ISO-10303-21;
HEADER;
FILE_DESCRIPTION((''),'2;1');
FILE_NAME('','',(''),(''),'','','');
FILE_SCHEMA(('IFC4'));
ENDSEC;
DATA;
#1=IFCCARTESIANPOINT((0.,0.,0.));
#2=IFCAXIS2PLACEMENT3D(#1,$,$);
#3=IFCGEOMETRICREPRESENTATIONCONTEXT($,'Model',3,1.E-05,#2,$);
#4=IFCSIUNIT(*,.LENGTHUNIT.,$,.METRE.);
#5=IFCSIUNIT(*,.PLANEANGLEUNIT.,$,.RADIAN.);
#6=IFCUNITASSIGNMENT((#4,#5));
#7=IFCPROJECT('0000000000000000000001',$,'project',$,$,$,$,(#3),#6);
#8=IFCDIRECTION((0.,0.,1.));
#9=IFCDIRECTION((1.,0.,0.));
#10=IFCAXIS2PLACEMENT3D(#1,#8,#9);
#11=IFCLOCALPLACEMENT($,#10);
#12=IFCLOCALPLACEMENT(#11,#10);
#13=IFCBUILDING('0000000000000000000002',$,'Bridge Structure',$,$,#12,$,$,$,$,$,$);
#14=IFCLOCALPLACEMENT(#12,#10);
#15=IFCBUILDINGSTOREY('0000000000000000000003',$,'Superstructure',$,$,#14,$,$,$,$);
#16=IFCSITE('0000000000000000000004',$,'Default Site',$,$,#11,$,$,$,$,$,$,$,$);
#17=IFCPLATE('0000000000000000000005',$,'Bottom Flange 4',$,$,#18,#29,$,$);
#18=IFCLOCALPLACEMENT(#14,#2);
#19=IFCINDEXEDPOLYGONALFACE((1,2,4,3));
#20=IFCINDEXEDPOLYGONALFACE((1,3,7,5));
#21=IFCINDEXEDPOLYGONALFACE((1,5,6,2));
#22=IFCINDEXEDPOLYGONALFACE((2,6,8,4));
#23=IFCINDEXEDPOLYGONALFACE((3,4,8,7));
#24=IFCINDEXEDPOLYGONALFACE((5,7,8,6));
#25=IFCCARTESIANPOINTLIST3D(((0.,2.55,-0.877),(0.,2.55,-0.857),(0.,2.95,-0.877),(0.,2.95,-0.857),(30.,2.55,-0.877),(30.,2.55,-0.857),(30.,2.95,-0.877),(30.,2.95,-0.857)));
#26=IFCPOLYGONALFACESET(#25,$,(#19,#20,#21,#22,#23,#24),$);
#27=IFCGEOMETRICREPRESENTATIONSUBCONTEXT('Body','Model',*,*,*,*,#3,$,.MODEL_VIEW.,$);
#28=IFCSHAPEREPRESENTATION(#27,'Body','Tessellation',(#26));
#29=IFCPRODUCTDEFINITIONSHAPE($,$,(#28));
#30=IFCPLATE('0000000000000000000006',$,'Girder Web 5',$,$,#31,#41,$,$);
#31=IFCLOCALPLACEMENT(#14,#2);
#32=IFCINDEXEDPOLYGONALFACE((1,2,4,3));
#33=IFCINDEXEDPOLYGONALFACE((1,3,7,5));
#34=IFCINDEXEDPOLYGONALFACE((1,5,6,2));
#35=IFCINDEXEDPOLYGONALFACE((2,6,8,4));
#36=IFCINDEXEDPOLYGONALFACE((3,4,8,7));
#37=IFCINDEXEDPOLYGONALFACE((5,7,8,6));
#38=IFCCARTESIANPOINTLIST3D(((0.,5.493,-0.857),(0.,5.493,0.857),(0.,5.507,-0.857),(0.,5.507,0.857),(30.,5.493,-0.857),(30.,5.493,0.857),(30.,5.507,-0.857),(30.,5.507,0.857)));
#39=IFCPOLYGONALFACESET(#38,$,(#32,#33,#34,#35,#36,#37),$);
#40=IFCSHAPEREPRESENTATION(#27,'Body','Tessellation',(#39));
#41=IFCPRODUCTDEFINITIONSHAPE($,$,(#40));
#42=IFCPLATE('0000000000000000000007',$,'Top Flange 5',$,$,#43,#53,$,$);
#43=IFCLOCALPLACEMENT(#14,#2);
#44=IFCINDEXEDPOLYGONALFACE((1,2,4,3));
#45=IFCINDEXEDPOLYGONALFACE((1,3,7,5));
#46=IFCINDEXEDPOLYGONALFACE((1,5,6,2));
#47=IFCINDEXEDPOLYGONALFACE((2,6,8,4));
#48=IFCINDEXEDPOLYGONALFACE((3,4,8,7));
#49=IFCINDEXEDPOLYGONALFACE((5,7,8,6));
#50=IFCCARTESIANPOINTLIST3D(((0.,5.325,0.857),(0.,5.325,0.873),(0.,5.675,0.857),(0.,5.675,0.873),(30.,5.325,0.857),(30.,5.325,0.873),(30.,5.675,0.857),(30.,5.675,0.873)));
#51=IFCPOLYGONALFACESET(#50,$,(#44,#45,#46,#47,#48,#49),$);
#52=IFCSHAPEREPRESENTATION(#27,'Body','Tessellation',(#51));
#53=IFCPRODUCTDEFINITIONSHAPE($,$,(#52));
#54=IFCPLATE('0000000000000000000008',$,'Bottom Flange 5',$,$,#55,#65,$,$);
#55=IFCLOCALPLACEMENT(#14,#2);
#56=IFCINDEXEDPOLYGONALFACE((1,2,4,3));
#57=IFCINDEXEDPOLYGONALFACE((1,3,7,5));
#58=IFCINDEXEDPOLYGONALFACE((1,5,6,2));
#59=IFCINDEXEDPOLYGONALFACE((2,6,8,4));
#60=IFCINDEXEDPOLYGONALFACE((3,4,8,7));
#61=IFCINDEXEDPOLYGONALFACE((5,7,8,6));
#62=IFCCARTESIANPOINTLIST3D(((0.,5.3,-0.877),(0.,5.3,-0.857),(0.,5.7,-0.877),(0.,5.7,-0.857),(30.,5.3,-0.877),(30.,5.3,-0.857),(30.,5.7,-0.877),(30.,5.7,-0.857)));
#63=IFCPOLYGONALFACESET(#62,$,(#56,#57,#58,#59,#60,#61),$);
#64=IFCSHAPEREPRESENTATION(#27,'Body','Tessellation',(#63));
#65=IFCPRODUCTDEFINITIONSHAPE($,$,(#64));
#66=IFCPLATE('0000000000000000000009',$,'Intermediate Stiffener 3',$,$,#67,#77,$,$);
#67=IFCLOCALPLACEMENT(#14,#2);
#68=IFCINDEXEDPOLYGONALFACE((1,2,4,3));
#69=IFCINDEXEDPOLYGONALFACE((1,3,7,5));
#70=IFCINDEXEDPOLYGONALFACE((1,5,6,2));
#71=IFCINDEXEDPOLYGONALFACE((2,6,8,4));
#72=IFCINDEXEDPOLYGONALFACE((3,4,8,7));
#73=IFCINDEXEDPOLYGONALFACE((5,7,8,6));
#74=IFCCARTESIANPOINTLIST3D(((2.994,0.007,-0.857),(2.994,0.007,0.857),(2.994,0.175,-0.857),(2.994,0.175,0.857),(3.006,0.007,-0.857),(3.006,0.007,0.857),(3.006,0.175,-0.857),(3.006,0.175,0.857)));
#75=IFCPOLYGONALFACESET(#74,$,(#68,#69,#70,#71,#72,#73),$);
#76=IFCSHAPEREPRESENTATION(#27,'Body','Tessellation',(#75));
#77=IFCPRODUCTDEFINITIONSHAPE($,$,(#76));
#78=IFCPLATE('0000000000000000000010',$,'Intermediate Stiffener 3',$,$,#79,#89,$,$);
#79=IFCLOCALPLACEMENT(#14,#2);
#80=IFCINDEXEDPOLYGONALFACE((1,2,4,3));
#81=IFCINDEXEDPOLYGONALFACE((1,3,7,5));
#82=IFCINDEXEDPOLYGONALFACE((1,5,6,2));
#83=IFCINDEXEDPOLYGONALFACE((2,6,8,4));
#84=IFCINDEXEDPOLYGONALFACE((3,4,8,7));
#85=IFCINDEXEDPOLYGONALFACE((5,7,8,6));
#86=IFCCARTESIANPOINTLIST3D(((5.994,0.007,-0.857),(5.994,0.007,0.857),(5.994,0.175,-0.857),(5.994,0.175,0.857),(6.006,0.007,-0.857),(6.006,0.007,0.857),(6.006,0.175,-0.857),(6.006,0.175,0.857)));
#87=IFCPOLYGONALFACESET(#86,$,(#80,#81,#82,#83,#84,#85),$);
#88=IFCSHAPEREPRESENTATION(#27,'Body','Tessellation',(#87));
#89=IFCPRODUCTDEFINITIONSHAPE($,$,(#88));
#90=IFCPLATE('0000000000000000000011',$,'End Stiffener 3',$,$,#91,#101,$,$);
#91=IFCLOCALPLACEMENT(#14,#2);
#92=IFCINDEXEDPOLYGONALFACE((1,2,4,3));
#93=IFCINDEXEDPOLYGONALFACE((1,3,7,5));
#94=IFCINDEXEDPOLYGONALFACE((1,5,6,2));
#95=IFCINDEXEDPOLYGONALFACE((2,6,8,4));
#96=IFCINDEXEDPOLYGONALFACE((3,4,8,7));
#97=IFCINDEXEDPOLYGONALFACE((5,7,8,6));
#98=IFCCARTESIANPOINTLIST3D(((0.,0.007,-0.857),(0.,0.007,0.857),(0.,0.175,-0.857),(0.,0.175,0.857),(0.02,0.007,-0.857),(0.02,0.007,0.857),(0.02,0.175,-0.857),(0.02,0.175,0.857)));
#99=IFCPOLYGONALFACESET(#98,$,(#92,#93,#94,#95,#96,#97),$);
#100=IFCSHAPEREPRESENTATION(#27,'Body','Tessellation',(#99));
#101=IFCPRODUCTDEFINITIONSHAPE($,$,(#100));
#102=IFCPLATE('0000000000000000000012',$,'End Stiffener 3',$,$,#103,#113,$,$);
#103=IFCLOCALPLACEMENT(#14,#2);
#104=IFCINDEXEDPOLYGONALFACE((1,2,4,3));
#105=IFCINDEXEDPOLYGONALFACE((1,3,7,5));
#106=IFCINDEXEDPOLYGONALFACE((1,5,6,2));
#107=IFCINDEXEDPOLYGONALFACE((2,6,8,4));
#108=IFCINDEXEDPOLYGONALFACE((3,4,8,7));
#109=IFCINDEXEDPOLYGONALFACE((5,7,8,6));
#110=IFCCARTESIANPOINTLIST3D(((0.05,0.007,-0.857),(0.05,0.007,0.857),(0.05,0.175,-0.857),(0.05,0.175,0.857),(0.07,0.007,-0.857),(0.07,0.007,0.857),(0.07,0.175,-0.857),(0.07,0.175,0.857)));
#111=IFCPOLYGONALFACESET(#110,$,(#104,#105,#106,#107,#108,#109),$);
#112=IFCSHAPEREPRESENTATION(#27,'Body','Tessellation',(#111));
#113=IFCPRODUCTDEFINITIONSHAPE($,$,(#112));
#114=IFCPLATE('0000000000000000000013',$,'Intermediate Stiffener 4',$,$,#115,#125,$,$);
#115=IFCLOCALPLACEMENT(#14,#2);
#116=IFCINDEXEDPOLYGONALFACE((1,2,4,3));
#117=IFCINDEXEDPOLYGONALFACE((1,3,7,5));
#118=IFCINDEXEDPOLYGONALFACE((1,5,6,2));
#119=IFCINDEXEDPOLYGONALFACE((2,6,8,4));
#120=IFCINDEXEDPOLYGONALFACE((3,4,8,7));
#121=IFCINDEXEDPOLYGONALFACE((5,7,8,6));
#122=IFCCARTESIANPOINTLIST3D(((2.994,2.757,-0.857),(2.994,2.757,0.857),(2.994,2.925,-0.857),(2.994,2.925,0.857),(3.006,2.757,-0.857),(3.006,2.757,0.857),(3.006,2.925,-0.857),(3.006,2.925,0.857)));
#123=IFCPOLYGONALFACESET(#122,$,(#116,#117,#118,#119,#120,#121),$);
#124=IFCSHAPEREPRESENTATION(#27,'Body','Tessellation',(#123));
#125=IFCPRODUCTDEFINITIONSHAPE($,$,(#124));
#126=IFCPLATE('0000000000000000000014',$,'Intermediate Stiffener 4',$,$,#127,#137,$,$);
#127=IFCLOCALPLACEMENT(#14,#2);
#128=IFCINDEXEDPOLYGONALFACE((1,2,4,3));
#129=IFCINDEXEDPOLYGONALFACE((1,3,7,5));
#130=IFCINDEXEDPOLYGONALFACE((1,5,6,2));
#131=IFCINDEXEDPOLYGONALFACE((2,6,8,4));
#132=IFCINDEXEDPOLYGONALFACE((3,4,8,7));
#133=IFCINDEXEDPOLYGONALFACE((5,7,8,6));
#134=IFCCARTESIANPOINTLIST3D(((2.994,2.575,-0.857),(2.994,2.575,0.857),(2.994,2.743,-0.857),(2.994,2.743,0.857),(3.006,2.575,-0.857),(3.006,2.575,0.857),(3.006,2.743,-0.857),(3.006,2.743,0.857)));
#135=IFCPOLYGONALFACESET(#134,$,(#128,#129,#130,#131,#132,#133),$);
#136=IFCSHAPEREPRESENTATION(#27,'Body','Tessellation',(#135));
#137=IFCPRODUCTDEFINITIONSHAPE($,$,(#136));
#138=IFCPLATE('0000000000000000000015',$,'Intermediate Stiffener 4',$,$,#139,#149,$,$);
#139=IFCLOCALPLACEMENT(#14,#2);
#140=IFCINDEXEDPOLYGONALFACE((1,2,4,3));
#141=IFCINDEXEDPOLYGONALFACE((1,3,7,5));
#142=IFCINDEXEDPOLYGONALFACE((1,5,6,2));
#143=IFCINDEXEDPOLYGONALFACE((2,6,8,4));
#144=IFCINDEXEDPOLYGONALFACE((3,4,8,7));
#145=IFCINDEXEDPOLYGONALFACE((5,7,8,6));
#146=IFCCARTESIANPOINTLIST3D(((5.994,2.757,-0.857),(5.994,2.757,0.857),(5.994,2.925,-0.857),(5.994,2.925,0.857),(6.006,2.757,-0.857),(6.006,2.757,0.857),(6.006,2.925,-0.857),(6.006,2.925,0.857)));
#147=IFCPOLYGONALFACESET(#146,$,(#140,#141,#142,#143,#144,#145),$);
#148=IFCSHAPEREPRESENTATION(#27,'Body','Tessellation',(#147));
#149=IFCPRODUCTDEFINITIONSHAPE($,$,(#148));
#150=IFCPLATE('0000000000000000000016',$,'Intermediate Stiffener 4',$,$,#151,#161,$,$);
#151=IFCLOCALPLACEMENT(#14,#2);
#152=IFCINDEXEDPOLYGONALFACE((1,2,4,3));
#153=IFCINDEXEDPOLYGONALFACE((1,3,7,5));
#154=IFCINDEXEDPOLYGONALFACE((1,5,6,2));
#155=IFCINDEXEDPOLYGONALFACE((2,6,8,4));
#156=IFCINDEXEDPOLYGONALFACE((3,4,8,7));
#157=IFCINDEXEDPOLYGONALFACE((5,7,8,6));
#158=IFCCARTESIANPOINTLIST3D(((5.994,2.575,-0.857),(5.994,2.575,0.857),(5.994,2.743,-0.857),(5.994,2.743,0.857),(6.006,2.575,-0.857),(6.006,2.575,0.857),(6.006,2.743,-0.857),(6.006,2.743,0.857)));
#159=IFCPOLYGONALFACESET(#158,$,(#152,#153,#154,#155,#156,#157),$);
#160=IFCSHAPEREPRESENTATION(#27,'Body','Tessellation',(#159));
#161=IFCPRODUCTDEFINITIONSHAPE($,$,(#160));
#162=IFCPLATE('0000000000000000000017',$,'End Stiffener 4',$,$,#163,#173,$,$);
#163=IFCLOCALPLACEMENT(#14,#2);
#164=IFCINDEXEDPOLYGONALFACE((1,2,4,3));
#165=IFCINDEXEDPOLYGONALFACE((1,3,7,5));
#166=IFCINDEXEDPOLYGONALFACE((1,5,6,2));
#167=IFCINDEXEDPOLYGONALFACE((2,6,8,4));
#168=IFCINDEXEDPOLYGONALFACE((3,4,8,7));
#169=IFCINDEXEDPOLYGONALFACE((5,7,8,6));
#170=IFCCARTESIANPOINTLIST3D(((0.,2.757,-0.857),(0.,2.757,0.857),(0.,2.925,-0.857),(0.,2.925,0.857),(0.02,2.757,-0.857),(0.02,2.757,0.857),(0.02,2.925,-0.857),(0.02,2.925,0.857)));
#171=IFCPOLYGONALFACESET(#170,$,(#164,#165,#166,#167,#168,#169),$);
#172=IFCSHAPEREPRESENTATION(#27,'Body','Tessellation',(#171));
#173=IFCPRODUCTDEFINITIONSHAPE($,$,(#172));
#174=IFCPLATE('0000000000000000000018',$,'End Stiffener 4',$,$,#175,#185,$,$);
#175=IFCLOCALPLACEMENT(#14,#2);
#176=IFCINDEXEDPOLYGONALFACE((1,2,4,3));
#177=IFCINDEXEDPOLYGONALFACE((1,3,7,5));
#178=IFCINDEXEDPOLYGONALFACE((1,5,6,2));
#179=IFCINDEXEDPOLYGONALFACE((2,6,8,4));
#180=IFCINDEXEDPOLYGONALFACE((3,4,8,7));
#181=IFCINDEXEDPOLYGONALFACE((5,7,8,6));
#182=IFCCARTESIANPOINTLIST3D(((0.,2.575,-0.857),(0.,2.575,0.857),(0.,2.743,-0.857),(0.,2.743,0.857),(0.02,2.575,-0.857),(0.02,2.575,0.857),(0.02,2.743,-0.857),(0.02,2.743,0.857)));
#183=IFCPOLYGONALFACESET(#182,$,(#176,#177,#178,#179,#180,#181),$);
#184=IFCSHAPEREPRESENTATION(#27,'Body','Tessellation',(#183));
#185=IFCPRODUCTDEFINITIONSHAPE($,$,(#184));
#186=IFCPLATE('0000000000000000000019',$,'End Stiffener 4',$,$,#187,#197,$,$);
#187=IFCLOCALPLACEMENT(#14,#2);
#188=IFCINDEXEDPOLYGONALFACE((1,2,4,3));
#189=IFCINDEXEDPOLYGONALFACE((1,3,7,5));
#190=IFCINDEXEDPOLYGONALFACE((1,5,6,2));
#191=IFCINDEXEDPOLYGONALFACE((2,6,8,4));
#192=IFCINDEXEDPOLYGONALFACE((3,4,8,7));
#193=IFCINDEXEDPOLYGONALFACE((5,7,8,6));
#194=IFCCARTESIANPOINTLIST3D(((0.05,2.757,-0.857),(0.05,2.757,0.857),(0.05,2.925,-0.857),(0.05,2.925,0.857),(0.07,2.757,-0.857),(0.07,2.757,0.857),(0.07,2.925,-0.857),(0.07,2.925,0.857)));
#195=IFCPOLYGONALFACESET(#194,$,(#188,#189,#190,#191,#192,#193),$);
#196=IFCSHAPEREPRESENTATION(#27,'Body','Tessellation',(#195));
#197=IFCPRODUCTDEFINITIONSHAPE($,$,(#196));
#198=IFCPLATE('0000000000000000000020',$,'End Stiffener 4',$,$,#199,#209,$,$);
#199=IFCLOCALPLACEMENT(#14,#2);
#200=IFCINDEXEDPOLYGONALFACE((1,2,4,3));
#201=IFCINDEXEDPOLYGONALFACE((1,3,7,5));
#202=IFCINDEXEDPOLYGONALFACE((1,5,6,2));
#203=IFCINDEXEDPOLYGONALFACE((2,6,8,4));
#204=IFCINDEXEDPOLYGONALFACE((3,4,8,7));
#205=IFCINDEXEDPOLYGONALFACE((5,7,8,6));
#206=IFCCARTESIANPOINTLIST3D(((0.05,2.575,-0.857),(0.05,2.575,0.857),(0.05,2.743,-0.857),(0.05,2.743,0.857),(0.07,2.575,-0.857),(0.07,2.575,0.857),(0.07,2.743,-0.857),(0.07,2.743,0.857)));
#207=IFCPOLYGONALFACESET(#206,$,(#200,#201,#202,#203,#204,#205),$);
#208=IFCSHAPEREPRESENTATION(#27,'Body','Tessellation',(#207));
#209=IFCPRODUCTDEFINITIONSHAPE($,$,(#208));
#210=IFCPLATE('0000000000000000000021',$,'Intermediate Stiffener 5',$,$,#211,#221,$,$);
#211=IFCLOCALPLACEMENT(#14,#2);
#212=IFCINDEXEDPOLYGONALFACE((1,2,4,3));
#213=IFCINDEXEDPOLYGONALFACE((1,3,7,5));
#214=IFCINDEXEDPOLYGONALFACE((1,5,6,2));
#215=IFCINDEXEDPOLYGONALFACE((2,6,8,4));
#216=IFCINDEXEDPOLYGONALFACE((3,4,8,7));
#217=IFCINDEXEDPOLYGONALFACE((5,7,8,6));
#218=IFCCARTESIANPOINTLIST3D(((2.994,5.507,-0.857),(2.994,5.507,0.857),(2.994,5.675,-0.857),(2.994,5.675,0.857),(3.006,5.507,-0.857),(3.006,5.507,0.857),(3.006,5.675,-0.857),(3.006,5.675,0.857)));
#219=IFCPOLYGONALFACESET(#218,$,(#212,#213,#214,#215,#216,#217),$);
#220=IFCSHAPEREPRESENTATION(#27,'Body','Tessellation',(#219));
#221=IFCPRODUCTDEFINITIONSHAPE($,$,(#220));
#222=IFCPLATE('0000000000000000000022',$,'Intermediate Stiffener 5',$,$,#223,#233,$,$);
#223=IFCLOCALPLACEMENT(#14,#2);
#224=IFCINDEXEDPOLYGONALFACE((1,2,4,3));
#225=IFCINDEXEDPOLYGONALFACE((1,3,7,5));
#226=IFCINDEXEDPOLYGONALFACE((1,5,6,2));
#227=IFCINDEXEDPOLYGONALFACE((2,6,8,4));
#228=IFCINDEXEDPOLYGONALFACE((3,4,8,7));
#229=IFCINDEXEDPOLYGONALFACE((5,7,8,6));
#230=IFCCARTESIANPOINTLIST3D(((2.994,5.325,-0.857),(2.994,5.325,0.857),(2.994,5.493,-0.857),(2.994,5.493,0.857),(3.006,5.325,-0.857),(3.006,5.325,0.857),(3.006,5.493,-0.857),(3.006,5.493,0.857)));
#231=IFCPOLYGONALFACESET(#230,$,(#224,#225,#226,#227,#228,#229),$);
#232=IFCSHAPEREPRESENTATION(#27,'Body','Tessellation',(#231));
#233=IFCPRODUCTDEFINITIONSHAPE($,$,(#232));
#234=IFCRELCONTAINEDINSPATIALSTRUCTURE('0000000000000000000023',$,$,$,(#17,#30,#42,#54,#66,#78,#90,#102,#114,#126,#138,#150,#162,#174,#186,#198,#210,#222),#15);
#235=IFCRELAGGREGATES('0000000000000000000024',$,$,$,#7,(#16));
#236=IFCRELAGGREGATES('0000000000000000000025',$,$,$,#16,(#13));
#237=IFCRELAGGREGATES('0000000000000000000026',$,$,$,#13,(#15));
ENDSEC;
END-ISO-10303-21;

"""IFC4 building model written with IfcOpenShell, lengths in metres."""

from ifc_helpers import new_model, si_unit, frame, origin, origin_with_axes, origin_2d_with_axis, place, context, subcontext, project, spatial, rectangle, extrude, element, save


model = new_model("IFC4")

# Units and contexts
model_context = context("Model", 3, precision=1e-05, world=origin())
body_context = subcontext(model_context, "Body", "Model", "MODEL_VIEW")
ifc_project = project(units=[si_unit("LENGTHUNIT", "METRE"), si_unit("PLANEANGLEUNIT", "RADIAN")], contexts=[model_context])

# Site, building, storey
site_placement = place(None, origin_with_axes())
site = spatial("IfcSite", under=ifc_project, at=site_placement, Name="Default Site")
building_placement = place(site_placement, origin_with_axes())
building = spatial("IfcBuilding", under=site, at=building_placement, Name="Bridge Structure")
storey_placement = place(building_placement, origin_with_axes())
storey = spatial("IfcBuildingStorey", under=building, at=storey_placement, Name="Superstructure")

# Plates
plate_1_placement = place(storey_placement, frame((0.0, 2.75, -0.867), z_axis=(1.0, 0.0, 0.0), x_axis=(0.0, 1.0, 0.0)))
element("IfcPlate", 1, at=plate_1_placement, inside=storey, Name="Bottom Flange 4", context=body_context, shape_type="SweptSolid", body=[
    extrude(rectangle(XDim=0.4, YDim=0.02, at=origin_2d_with_axis()), origin_with_axes(), (0.0, 0.0, 1.0), 30.0),
])
plate_2_placement = place(storey_placement, frame((0.0, 5.5, 0.0), z_axis=(1.0, 0.0, 0.0), x_axis=(0.0, 1.0, 0.0)))
element("IfcPlate", 2, at=plate_2_placement, inside=storey, Name="Girder Web 5", context=body_context, shape_type="SweptSolid", body=[
    extrude(rectangle(XDim=0.014, YDim=1.714, at=origin_2d_with_axis()), origin_with_axes(), (0.0, 0.0, 1.0), 30.0),
])
plate_3_placement = place(storey_placement, frame((0.0, 5.5, 0.865), z_axis=(1.0, 0.0, 0.0), x_axis=(0.0, 1.0, 0.0)))
element("IfcPlate", 3, at=plate_3_placement, inside=storey, Name="Top Flange 5", context=body_context, shape_type="SweptSolid", body=[
    extrude(rectangle(XDim=0.35, YDim=0.016, at=origin_2d_with_axis()), origin_with_axes(), (0.0, 0.0, 1.0), 30.0),
])
plate_4_placement = place(storey_placement, frame((0.0, 5.5, -0.867), z_axis=(1.0, 0.0, 0.0), x_axis=(0.0, 1.0, 0.0)))
element("IfcPlate", 4, at=plate_4_placement, inside=storey, Name="Bottom Flange 5", context=body_context, shape_type="SweptSolid", body=[
    extrude(rectangle(XDim=0.4, YDim=0.02, at=origin_2d_with_axis()), origin_with_axes(), (0.0, 0.0, 1.0), 30.0),
])
for number, where, z_axis, x_axis, name in (
    (5, (3.0, 0.091, -0.857), (0.0, 0.0, 1.0), (1.0, 0.0, 0.0), "Intermediate Stiffener 3"),
    (6, (6.0, 0.091, -0.857), (0.0, 0.0, 1.0), (1.0, 0.0, 0.0), "Intermediate Stiffener 3"),
):
    element("IfcPlate", number, at=place(storey_placement, frame(where, z_axis=z_axis, x_axis=x_axis)), inside=storey, Name=name, context=body_context, shape_type="SweptSolid", body=[
        extrude(rectangle(XDim=0.012, YDim=0.168, at=origin_2d_with_axis()), origin_with_axes(), (0.0, 0.0, 1.0), 1.714),
    ])
for number, where, z_axis, x_axis, name in (
    (7, (0.01, 0.091, -0.857), (0.0, 0.0, 1.0), (1.0, 0.0, 0.0), "End Stiffener 3"),
    (8, (0.06, 0.091, -0.857), (0.0, 0.0, 1.0), (1.0, 0.0, 0.0), "End Stiffener 3"),
):
    element("IfcPlate", number, at=place(storey_placement, frame(where, z_axis=z_axis, x_axis=x_axis)), inside=storey, Name=name, context=body_context, shape_type="SweptSolid", body=[
        extrude(rectangle(XDim=0.02, YDim=0.168, at=origin_2d_with_axis()), origin_with_axes(), (0.0, 0.0, 1.0), 1.714),
    ])
for number, where, z_axis, x_axis, name in (
    (9, (3.0, 2.841, -0.857), (0.0, 0.0, 1.0), (1.0, 0.0, 0.0), "Intermediate Stiffener 4"),
    (10, (3.0, 2.659, -0.857), (0.0, 0.0, 1.0), (1.0, 0.0, 0.0), "Intermediate Stiffener 4"),
    (11, (6.0, 2.841, -0.857), (0.0, 0.0, 1.0), (1.0, 0.0, 0.0), "Intermediate Stiffener 4"),
    (12, (6.0, 2.659, -0.857), (0.0, 0.0, 1.0), (1.0, 0.0, 0.0), "Intermediate Stiffener 4"),
):
    element("IfcPlate", number, at=place(storey_placement, frame(where, z_axis=z_axis, x_axis=x_axis)), inside=storey, Name=name, context=body_context, shape_type="SweptSolid", body=[
        extrude(rectangle(XDim=0.012, YDim=0.168, at=origin_2d_with_axis()), origin_with_axes(), (0.0, 0.0, 1.0), 1.714),
    ])
for number, where, z_axis, x_axis, name in (
    (13, (0.01, 2.841, -0.857), (0.0, 0.0, 1.0), (1.0, 0.0, 0.0), "End Stiffener 4"),
    (14, (0.01, 2.659, -0.857), (0.0, 0.0, 1.0), (1.0, 0.0, 0.0), "End Stiffener 4"),
    (15, (0.06, 2.841, -0.857), (0.0, 0.0, 1.0), (1.0, 0.0, 0.0), "End Stiffener 4"),
    (16, (0.06, 2.659, -0.857), (0.0, 0.0, 1.0), (1.0, 0.0, 0.0), "End Stiffener 4"),
):
    element("IfcPlate", number, at=place(storey_placement, frame(where, z_axis=z_axis, x_axis=x_axis)), inside=storey, Name=name, context=body_context, shape_type="SweptSolid", body=[
        extrude(rectangle(XDim=0.02, YDim=0.168, at=origin_2d_with_axis()), origin_with_axes(), (0.0, 0.0, 1.0), 1.714),
    ])
for number, where, z_axis, x_axis, name in (
    (17, (3.0, 5.591, -0.857), (0.0, 0.0, 1.0), (1.0, 0.0, 0.0), "Intermediate Stiffener 5"),
    (18, (3.0, 5.409, -0.857), (0.0, 0.0, 1.0), (1.0, 0.0, 0.0), "Intermediate Stiffener 5"),
):
    element("IfcPlate", number, at=place(storey_placement, frame(where, z_axis=z_axis, x_axis=x_axis)), inside=storey, Name=name, context=body_context, shape_type="SweptSolid", body=[
        extrude(rectangle(XDim=0.012, YDim=0.168, at=origin_2d_with_axis()), origin_with_axes(), (0.0, 0.0, 1.0), 1.714),
    ])

save(model, "model.ifc")
